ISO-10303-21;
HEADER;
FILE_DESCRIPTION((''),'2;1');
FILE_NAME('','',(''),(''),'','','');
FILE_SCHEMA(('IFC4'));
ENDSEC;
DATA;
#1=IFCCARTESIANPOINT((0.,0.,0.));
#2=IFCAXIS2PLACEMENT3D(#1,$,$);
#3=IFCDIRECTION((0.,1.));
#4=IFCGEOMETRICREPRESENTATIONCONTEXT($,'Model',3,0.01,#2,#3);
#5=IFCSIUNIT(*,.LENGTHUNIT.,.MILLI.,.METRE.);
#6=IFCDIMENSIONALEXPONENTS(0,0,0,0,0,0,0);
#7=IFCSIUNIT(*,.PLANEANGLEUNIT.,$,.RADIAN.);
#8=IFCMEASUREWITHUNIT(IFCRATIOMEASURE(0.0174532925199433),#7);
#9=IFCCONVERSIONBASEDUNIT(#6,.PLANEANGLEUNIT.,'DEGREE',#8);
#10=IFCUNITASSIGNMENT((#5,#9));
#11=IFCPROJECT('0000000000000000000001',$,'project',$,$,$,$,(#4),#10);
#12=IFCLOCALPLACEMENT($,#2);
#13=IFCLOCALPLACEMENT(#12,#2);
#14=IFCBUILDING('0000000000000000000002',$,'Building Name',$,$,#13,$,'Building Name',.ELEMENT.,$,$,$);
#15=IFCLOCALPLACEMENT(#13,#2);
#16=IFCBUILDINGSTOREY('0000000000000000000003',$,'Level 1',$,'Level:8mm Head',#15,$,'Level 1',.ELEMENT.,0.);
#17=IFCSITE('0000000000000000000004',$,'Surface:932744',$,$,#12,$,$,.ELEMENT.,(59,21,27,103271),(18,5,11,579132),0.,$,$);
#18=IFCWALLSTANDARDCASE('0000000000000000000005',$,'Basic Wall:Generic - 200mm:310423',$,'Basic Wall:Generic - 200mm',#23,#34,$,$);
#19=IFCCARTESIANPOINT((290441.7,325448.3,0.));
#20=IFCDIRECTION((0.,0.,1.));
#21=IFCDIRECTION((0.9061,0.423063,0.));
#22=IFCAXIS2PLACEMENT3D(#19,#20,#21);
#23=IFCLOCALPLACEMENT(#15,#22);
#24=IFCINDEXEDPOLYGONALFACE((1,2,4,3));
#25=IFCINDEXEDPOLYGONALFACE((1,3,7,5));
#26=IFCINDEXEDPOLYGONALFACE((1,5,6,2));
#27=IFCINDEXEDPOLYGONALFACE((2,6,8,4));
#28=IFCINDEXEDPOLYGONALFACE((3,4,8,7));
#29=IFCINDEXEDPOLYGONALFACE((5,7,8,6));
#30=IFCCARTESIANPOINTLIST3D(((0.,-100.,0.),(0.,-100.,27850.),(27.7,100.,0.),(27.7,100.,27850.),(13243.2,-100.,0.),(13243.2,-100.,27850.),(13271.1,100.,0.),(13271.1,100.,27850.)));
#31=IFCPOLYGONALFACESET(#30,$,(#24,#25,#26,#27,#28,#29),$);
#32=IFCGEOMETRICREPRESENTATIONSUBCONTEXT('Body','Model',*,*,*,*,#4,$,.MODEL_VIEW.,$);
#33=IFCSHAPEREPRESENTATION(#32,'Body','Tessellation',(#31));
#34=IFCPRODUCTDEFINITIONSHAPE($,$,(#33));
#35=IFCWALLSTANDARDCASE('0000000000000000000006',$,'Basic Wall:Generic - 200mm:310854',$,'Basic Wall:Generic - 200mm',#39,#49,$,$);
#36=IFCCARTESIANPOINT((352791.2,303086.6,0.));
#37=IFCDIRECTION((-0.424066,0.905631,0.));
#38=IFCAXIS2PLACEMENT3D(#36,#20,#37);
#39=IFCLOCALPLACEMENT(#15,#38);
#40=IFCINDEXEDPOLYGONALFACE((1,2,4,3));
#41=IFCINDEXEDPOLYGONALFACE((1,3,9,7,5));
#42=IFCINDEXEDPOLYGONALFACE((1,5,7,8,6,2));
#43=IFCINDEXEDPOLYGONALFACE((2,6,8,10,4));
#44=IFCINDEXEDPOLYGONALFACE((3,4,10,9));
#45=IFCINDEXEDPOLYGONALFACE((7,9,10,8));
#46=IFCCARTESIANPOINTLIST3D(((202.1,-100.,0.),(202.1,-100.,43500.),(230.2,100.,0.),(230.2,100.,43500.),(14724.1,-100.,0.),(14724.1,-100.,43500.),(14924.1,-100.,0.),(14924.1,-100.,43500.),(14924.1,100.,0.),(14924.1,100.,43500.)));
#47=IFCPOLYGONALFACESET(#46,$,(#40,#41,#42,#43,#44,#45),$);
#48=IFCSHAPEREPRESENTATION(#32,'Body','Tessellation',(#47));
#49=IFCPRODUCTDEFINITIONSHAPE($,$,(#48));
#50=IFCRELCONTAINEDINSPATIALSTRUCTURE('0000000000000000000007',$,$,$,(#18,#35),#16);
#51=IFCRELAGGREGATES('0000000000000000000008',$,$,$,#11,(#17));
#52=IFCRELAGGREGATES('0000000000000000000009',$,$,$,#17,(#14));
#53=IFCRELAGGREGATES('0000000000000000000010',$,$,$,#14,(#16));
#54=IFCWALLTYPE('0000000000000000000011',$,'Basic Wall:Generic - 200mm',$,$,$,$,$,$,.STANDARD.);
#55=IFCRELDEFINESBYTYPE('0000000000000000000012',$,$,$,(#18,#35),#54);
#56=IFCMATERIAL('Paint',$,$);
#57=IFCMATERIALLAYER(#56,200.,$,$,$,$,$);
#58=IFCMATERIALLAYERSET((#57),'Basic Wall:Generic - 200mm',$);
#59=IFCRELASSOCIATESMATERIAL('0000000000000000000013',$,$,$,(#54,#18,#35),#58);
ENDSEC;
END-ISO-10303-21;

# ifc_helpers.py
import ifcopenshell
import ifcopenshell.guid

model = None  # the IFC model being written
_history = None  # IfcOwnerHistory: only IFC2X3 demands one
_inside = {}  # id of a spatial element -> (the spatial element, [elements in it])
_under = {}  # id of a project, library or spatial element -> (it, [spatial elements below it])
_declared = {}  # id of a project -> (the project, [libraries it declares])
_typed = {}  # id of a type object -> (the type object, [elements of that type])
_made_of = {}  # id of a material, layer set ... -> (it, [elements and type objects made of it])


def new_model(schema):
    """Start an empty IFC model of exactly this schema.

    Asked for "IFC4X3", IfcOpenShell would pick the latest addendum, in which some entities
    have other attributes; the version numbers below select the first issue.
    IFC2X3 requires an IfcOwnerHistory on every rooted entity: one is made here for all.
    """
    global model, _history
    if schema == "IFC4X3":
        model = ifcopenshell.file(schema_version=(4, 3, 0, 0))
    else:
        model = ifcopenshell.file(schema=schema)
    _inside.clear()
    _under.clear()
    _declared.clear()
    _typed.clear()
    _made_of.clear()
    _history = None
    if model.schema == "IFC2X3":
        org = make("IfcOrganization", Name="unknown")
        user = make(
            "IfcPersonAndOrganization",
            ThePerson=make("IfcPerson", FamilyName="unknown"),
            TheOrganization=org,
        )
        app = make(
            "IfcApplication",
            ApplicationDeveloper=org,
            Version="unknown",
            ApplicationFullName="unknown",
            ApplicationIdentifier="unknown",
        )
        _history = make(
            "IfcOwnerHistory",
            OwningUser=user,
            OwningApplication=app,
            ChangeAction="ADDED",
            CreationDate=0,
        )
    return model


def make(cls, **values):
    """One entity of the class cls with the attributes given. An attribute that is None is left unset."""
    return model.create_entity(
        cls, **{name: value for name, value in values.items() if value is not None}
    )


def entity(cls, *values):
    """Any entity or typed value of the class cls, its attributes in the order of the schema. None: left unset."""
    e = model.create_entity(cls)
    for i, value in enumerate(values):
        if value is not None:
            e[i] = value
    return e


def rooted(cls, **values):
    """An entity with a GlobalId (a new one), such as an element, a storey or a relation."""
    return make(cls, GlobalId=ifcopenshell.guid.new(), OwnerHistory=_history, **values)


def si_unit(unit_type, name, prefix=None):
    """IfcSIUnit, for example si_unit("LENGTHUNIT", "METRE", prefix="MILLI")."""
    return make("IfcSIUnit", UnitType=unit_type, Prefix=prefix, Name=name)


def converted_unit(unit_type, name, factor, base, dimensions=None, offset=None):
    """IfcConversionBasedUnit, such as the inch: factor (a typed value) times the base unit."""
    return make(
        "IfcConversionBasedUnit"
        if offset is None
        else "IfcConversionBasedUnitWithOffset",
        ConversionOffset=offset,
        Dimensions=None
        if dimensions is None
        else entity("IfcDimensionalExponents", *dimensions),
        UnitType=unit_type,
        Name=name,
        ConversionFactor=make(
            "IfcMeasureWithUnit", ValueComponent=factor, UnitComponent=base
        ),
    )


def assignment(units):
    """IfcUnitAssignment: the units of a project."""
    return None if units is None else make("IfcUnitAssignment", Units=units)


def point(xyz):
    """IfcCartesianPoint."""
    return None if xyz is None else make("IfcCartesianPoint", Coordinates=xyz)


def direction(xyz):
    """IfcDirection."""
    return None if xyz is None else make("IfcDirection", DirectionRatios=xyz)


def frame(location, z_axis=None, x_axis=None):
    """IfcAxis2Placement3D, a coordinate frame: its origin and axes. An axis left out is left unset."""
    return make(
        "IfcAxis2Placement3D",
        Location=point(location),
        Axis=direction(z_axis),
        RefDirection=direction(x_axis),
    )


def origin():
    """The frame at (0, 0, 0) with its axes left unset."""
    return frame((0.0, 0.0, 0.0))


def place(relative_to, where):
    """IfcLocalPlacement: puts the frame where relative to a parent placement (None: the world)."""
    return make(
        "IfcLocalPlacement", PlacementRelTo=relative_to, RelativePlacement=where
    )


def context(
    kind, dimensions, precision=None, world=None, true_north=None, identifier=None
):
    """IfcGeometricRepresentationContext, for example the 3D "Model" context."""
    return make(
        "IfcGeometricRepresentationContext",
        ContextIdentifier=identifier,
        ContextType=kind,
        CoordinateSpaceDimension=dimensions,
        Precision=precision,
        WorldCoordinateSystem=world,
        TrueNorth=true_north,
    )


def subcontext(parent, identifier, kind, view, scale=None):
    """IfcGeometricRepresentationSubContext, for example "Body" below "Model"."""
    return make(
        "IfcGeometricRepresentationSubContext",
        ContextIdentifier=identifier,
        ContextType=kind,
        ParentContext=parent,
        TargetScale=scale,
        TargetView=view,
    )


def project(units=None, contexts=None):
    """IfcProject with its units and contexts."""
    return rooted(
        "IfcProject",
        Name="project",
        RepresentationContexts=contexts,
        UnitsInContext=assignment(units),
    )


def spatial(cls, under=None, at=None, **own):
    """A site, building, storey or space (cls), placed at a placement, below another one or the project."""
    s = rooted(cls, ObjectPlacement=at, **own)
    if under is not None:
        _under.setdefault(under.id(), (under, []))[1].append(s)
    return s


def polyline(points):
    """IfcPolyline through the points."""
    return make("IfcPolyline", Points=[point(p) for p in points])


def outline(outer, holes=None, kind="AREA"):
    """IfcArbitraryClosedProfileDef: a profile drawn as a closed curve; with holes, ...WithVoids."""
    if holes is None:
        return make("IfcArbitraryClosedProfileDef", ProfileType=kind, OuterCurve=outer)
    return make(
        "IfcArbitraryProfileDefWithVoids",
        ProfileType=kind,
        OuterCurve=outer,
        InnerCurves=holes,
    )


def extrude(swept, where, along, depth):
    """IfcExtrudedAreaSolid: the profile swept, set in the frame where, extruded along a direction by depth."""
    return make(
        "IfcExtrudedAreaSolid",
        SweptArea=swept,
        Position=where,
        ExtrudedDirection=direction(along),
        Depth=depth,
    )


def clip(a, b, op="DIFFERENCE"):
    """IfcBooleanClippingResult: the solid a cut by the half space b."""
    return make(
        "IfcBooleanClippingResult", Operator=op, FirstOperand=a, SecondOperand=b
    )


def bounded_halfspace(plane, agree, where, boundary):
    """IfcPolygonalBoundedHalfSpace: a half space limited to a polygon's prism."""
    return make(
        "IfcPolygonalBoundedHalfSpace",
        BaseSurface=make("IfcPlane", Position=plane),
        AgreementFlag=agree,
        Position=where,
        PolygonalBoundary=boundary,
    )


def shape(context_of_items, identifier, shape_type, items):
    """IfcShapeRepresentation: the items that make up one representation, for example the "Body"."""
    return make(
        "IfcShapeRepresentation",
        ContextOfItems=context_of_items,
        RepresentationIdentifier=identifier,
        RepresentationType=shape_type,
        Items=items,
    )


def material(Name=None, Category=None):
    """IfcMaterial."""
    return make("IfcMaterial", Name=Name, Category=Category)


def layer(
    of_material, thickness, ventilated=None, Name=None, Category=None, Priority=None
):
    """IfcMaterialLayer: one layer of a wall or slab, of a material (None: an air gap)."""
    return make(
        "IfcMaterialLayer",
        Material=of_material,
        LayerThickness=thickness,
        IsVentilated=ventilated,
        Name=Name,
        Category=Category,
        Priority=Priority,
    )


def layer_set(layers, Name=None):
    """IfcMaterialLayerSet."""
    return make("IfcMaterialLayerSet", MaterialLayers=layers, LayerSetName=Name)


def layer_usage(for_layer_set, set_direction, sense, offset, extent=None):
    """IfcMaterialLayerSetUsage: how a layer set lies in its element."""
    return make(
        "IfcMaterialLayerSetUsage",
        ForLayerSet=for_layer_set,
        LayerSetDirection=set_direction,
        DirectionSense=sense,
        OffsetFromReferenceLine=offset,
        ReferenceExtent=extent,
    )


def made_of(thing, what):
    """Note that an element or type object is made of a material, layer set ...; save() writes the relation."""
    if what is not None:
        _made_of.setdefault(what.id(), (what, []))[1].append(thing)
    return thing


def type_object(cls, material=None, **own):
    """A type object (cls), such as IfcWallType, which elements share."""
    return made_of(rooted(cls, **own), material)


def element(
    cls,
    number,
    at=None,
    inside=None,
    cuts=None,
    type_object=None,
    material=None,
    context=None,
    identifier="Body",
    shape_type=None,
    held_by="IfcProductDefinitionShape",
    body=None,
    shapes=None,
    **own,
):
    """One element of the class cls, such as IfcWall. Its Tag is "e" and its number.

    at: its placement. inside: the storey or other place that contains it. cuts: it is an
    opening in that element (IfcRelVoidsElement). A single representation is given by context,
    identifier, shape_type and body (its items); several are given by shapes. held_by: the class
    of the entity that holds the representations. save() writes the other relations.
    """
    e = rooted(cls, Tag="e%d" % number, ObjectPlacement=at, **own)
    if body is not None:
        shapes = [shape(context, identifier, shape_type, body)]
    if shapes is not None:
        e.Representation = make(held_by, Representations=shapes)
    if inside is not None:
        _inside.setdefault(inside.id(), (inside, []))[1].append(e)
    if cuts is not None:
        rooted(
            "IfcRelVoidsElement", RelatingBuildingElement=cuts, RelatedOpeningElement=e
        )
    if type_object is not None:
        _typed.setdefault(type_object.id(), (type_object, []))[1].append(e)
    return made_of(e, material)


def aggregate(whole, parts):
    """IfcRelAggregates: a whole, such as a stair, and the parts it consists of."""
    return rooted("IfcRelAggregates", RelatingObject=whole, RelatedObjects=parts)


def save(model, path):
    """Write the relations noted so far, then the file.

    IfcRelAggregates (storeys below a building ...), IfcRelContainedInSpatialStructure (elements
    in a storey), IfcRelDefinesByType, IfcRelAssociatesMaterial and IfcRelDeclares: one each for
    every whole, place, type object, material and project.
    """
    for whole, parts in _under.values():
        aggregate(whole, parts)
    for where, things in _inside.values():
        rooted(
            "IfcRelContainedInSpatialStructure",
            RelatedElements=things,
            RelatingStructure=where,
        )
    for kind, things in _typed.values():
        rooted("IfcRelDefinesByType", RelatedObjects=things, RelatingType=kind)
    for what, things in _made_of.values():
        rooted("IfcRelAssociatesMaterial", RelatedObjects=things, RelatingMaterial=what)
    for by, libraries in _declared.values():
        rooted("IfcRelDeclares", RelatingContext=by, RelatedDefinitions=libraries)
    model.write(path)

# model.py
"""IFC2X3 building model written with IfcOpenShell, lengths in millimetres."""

from ifc_helpers import new_model, entity, si_unit, converted_unit, direction, frame, origin, place, context, subcontext, project, spatial, polyline, outline, extrude, clip, bounded_halfspace, material, layer, layer_set, layer_usage, type_object, element, save


model = new_model("IFC2X3")

# Units and contexts
model_context = context("Model", 3, precision=0.01, world=origin(), true_north=direction((0.0, 1.0)))
body_context = subcontext(model_context, "Body", "Model", "MODEL_VIEW")
ifc_project = project(units=[si_unit("LENGTHUNIT", "METRE", prefix="MILLI"), converted_unit("PLANEANGLEUNIT", "DEGREE", entity("IfcRatioMeasure", 0.0174532925199433), si_unit("PLANEANGLEUNIT", "RADIAN"), dimensions=[0, 0, 0, 0, 0, 0, 0])], contexts=[model_context])

# Site, building, storey
site_placement = place(None, origin())
site = spatial("IfcSite", under=ifc_project, at=site_placement, Name="Surface:932744", CompositionType="ELEMENT", RefLatitude=(59, 21, 27, 103271), RefLongitude=(18, 5, 11, 579132), RefElevation=0.0)
building_placement = place(site_placement, origin())
building = spatial("IfcBuilding", under=site, at=building_placement, Name="Building Name", LongName="Building Name", CompositionType="ELEMENT")
storey_placement = place(building_placement, origin())
storey = spatial("IfcBuildingStorey", under=building, at=storey_placement, Name="Level 1", ObjectType="Level:8mm Head", LongName="Level 1", CompositionType="ELEMENT", Elevation=0.0)

# Wall
ifc_material_1 = material(Name="Paint")
ifc_layer_1 = layer(ifc_material_1, 200.0)
ifc_layer_set_1 = layer_set([ifc_layer_1], Name="Basic Wall:Generic - 200mm")
wall_type_1 = type_object("IfcWallType", Name="Basic Wall:Generic - 200mm", PredefinedType="STANDARD", material=ifc_layer_set_1)
ifc_layer_usage_1 = layer_usage(ifc_layer_set_1, "AXIS2", "NEGATIVE", 100.0)
wall_1_placement = place(storey_placement, frame((290441.7, 325448.3, 0.0), z_axis=(0.0, 0.0, 1.0), x_axis=(0.9061, 0.423063, 0.0)))
element("IfcWallStandardCase", 1, at=wall_1_placement, inside=storey, type_object=wall_type_1, material=ifc_layer_usage_1, Name="Basic Wall:Generic - 200mm:310423", ObjectType="Basic Wall:Generic - 200mm", context=body_context, shape_type="Clipping", body=[
    clip(extrude(outline(polyline([(13243.2, -100.0), (13271.1, 100.0), (27.7, 100.0), (0.0, -100.0), (13041.2, -100.0), (13243.2, -100.0)])), origin(), (0.0, 0.0, 1.0), 27850.0), bounded_halfspace(frame((0.0, -100.0, 27850.0), z_axis=(0.0, 0.0, -1.0), x_axis=(0.990494, -0.137556, 0.0)), True, frame((0.0, -100.0, 27850.0), z_axis=(0.0, 0.0, -1.0), x_axis=(0.990494, -0.137556, 0.0)), polyline([(0.0, 0.0), (-0.1, -201.9), (13117.4, -2023.6), (13117.3, -1821.7), (0.0, 0.0)]))),
])

# Wall
ifc_layer_usage_2 = layer_usage(ifc_layer_set_1, "AXIS2", "NEGATIVE", 100.0)
wall_2_placement = place(storey_placement, frame((352791.2, 303086.6, 0.0), z_axis=(0.0, 0.0, 1.0), x_axis=(-0.424066, 0.905631, 0.0)))
element("IfcWallStandardCase", 2, at=wall_2_placement, inside=storey, type_object=wall_type_1, material=ifc_layer_usage_2, Name="Basic Wall:Generic - 200mm:310854", ObjectType="Basic Wall:Generic - 200mm", context=body_context, shape_type="SweptSolid", body=[
    extrude(outline(polyline([(14924.1, -100.0), (14924.1, 100.0), (230.2, 100.0), (202.1, -100.0), (14724.1, -100.0), (14924.1, -100.0)])), origin(), (0.0, 0.0, 1.0), 43500.0),
])

save(model, "model.ifc")
